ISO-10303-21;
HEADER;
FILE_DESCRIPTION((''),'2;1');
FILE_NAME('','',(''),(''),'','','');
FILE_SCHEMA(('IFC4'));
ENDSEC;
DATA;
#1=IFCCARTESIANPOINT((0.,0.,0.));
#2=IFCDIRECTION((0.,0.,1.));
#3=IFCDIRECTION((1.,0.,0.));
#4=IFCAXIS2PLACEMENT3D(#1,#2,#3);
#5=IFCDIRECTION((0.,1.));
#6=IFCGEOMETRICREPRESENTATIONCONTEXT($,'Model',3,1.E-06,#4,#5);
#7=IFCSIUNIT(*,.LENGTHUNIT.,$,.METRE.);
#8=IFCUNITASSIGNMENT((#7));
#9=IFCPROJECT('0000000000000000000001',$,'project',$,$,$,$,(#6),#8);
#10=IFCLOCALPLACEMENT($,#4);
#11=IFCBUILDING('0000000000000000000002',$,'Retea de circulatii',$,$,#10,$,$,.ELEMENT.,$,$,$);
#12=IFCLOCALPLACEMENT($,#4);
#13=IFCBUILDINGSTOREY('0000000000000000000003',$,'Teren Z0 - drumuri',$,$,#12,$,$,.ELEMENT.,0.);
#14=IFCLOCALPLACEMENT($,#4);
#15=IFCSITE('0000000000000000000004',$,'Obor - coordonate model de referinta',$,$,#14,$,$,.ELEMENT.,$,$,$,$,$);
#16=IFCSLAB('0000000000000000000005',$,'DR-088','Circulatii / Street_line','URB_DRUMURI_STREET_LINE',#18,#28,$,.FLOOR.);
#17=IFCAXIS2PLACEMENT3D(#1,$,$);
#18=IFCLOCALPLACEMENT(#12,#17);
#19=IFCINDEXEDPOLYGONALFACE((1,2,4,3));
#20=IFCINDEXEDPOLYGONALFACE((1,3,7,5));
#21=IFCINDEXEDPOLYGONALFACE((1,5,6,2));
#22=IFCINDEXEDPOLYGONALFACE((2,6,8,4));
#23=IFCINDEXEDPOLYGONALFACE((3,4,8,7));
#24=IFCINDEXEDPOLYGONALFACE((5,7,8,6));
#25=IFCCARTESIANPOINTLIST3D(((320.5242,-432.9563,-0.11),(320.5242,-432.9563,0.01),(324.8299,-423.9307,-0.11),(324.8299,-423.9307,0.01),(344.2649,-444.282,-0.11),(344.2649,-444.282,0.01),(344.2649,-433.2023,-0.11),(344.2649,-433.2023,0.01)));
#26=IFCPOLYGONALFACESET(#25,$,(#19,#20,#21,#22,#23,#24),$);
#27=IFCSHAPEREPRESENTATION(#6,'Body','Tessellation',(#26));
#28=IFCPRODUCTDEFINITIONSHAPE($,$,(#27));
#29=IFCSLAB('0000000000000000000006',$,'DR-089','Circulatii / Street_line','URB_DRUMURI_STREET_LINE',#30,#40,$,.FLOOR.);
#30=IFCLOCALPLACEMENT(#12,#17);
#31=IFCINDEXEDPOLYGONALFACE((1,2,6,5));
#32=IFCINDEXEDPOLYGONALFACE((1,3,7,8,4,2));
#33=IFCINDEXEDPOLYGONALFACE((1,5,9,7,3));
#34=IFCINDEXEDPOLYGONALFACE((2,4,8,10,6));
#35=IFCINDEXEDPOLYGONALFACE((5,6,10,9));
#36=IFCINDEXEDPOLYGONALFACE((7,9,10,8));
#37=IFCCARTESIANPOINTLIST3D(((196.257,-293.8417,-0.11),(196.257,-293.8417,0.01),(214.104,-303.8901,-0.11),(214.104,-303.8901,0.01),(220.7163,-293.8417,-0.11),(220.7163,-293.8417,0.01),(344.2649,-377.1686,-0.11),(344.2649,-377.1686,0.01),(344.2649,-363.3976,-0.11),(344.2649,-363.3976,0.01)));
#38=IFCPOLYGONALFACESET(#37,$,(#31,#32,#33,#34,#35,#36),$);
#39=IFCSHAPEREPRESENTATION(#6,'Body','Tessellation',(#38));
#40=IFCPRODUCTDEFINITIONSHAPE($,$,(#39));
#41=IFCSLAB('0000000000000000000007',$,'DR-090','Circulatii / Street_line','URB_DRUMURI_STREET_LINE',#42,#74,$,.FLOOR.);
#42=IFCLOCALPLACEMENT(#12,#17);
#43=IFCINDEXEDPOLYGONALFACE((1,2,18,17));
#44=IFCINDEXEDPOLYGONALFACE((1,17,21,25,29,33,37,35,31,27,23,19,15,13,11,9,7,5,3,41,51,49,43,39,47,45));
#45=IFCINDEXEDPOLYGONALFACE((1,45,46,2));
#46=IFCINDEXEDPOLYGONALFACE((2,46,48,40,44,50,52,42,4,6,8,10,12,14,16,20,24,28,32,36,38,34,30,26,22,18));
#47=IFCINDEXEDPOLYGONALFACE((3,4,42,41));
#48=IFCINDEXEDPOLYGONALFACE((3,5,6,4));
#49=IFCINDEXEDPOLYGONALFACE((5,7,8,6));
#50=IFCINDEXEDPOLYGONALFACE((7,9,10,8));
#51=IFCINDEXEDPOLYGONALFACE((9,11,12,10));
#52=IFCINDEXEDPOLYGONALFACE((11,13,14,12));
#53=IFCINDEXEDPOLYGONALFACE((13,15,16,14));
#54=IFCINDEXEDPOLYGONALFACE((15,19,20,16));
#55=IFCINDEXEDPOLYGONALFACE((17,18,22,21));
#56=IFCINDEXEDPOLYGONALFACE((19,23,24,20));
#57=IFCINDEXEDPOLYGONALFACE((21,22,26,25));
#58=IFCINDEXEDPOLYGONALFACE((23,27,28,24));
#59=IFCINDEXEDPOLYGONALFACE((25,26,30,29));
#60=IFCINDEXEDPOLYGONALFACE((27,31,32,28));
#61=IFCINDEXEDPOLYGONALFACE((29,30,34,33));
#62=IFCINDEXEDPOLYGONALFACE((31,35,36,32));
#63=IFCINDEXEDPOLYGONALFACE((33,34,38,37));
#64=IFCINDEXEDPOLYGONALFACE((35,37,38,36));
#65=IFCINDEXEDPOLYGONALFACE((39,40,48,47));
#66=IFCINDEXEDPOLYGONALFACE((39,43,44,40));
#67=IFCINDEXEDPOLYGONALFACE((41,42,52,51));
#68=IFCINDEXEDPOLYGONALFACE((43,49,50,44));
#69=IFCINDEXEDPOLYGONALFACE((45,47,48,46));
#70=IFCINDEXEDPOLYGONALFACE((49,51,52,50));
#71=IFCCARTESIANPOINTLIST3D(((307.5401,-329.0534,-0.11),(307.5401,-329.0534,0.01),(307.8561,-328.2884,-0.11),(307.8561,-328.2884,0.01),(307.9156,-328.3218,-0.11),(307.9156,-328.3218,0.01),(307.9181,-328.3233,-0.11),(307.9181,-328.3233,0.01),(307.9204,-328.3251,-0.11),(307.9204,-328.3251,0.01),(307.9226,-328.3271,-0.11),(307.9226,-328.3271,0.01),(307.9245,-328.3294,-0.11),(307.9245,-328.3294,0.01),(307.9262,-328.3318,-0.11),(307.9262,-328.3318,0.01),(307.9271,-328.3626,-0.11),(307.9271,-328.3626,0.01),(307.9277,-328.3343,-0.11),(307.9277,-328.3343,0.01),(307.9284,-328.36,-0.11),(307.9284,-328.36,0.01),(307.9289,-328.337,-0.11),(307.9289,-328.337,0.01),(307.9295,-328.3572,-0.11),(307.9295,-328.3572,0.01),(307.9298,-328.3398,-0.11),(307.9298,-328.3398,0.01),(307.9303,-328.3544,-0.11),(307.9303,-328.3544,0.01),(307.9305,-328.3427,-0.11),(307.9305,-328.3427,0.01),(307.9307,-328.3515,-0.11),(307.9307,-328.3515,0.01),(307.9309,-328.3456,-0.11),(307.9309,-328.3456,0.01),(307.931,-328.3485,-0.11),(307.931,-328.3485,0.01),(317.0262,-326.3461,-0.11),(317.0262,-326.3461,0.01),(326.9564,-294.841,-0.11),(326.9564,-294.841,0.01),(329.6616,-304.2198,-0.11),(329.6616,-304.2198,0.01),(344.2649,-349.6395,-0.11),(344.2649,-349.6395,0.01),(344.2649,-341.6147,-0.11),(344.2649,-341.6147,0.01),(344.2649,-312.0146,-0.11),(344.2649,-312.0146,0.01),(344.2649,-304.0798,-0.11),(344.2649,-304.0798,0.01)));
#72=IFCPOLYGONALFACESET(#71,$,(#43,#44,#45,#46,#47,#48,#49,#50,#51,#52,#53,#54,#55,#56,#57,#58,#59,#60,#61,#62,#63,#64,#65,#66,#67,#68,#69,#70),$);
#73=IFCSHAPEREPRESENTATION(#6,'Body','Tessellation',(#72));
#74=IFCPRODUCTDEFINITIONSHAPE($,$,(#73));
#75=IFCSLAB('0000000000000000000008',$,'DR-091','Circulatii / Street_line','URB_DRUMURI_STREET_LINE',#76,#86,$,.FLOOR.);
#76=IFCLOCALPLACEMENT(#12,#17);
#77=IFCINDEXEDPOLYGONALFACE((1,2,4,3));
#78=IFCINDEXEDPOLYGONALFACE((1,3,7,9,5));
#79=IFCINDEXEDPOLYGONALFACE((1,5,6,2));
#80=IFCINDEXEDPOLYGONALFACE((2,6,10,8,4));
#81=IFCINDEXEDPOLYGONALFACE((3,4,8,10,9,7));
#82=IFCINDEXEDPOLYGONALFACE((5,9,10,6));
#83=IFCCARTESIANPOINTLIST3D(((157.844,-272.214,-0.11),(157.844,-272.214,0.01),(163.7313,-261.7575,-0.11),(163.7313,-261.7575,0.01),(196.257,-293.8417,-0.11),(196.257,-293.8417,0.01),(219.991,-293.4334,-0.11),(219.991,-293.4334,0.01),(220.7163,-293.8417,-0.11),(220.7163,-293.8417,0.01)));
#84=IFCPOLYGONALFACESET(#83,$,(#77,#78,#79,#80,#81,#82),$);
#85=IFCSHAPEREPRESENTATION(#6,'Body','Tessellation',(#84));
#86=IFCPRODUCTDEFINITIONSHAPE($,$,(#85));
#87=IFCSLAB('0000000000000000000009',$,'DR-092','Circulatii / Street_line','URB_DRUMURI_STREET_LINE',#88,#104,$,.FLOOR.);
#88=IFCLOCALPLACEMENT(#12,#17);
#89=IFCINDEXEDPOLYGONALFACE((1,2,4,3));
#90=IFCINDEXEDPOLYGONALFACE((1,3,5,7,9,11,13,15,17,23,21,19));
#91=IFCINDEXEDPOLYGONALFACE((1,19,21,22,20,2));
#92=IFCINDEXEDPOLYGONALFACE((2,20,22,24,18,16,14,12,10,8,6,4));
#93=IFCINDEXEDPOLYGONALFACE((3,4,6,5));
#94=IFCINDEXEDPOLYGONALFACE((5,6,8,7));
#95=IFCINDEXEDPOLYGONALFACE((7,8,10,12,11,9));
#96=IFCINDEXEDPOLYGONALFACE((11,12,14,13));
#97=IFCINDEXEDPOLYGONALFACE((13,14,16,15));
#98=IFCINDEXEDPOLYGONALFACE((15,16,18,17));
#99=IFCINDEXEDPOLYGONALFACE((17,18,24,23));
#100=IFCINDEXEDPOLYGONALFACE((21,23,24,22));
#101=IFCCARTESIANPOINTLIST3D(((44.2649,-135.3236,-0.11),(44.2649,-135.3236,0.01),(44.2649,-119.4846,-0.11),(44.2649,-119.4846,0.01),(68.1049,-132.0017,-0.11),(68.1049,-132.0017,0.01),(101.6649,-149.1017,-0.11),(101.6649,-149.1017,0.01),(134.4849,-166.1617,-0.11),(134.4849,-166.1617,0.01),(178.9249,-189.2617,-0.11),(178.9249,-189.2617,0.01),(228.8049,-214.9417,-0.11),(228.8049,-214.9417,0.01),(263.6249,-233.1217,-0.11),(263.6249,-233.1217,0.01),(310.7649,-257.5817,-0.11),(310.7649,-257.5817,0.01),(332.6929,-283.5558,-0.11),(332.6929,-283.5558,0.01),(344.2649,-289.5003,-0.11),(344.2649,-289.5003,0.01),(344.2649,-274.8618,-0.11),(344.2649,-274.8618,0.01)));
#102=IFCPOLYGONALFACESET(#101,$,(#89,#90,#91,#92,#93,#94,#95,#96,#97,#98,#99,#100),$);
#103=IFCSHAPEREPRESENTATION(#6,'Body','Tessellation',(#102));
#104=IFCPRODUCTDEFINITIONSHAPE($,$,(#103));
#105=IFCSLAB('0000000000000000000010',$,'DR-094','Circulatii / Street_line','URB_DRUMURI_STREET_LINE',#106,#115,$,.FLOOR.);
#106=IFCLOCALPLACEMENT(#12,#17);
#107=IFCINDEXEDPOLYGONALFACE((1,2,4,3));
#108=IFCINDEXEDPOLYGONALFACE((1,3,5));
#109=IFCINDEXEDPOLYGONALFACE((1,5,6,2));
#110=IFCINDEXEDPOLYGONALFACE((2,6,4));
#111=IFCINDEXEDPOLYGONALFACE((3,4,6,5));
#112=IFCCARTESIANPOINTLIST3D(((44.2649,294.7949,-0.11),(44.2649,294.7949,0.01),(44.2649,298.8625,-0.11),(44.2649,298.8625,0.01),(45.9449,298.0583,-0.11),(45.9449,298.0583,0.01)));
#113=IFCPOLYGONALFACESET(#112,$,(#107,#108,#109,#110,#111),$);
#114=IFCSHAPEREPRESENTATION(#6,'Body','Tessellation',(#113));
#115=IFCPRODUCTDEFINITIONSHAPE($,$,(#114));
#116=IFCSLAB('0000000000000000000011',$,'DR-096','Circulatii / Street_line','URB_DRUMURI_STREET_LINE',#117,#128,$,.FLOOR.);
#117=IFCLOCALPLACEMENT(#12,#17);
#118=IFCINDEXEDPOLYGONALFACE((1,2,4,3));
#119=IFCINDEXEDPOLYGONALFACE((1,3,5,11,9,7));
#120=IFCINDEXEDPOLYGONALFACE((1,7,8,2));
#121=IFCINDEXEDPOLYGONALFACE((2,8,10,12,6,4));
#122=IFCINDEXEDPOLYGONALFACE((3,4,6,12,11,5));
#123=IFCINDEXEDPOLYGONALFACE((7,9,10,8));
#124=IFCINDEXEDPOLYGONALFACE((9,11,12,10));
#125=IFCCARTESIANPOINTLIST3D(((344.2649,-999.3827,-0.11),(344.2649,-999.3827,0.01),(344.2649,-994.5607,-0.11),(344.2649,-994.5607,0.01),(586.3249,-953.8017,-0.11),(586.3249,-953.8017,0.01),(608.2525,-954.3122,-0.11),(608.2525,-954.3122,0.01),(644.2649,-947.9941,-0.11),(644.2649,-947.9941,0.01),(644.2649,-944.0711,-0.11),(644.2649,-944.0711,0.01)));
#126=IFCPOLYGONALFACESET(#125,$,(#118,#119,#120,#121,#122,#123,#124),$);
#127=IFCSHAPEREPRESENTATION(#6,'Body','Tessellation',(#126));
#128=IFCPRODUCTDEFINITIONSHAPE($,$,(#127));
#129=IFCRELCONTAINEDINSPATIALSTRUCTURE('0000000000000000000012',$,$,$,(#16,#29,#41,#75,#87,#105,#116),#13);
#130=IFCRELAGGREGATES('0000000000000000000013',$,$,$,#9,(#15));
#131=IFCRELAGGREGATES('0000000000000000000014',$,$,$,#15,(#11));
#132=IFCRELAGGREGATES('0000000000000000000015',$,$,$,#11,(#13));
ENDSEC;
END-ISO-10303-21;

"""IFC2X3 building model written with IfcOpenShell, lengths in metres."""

from ifc_helpers import new_model, si_unit, direction, frame, origin_with_axes, place, context, project, spatial, polyline, outline, extrude, element, save


model = new_model("IFC2X3")

# Units and contexts
model_context = context("Model", 3, precision=1e-06, world=origin_with_axes(), true_north=direction((0.0, 1.0)))
ifc_project = project(units=[si_unit("LENGTHUNIT", "METRE")], contexts=[model_context])

# Site, building, storey
site_placement = place(None, origin_with_axes())
site = spatial("IfcSite", under=ifc_project, at=site_placement, Name="Obor - coordonate model de referinta", CompositionType="ELEMENT")
building_placement = place(None, origin_with_axes())
building = spatial("IfcBuilding", under=site, at=building_placement, Name="Retea de circulatii", CompositionType="ELEMENT")
storey_placement = place(None, origin_with_axes())
storey = spatial("IfcBuildingStorey", under=building, at=storey_placement, Name="Teren Z0 - drumuri", CompositionType="ELEMENT", Elevation=0.0)

# Slabs
slab_1_placement = place(None, origin_with_axes())
element("IfcSlab", 1, at=slab_1_placement, inside=storey, Name="DR-088", Description="Circulatii / Street_line", ObjectType="URB_DRUMURI_STREET_LINE", PredefinedType="FLOOR", context=model_context, shape_type="SweptSolid", body=[
    extrude(outline(polyline([(344.2649, -433.2023), (324.8299, -423.9307), (320.5242, -432.9563), (344.2649, -444.282), (344.2649, -433.2023)])), frame((0.0, 0.0, -0.11), z_axis=(0.0, 0.0, 1.0), x_axis=(1.0, 0.0, 0.0)), (0.0, 0.0, 1.0), 0.12),
])
slab_2_placement = place(None, origin_with_axes())
element("IfcSlab", 2, at=slab_2_placement, inside=storey, Name="DR-089", Description="Circulatii / Street_line", ObjectType="URB_DRUMURI_STREET_LINE", PredefinedType="FLOOR", context=model_context, shape_type="SweptSolid", body=[
    extrude(outline(polyline([(220.7163, -293.8417), (196.257, -293.8417), (214.104, -303.8901), (344.2649, -377.1686), (344.2649, -363.3976), (220.7163, -293.8417)])), frame((0.0, 0.0, -0.11), z_axis=(0.0, 0.0, 1.0), x_axis=(1.0, 0.0, 0.0)), (0.0, 0.0, 1.0), 0.12),
])
slab_3_placement = place(None, origin_with_axes())
element("IfcSlab", 3, at=slab_3_placement, inside=storey, Name="DR-090", Description="Circulatii / Street_line", ObjectType="URB_DRUMURI_STREET_LINE", PredefinedType="FLOOR", context=model_context, shape_type="SweptSolid", body=[
    extrude(outline(polyline([(307.9284, -328.36), (307.9271, -328.3626), (307.5401, -329.0534), (344.2649, -349.6395), (344.2649, -341.6147), (317.0262, -326.3461), (329.6616, -304.2198), (344.2649, -312.0146), (344.2649, -304.0798), (326.9564, -294.841), (307.8561, -328.2884), (307.9156, -328.3218), (307.9181, -328.3233), (307.9204, -328.3251), (307.9226, -328.3271), (307.9245, -328.3294), (307.9262, -328.3318), (307.9277, -328.3343), (307.9289, -328.337), (307.9298, -328.3398), (307.9305, -328.3427), (307.9309, -328.3456), (307.931, -328.3485), (307.9307, -328.3515), (307.9303, -328.3544), (307.9295, -328.3572), (307.9284, -328.36)])), frame((0.0, 0.0, -0.11), z_axis=(0.0, 0.0, 1.0), x_axis=(1.0, 0.0, 0.0)), (0.0, 0.0, 1.0), 0.12),
])
slab_4_placement = place(None, origin_with_axes())
element("IfcSlab", 4, at=slab_4_placement, inside=storey, Name="DR-091", Description="Circulatii / Street_line", ObjectType="URB_DRUMURI_STREET_LINE", PredefinedType="FLOOR", context=model_context, shape_type="SweptSolid", body=[
    extrude(outline(polyline([(163.7313, -261.7575), (157.844, -272.214), (196.257, -293.8417), (220.7163, -293.8417), (219.991, -293.4334), (163.7313, -261.7575)])), frame((0.0, 0.0, -0.11), z_axis=(0.0, 0.0, 1.0), x_axis=(1.0, 0.0, 0.0)), (0.0, 0.0, 1.0), 0.12),
])
slab_5_placement = place(None, origin_with_axes())
element("IfcSlab", 5, at=slab_5_placement, inside=storey, Name="DR-092", Description="Circulatii / Street_line", ObjectType="URB_DRUMURI_STREET_LINE", PredefinedType="FLOOR", context=model_context, shape_type="SweptSolid", body=[
    extrude(outline(polyline([(44.2649, -135.3236), (332.6929, -283.5558), (344.2649, -289.5003), (344.2649, -274.8618), (310.7649, -257.5817), (263.6249, -233.1217), (228.8049, -214.9417), (178.9249, -189.2617), (134.4849, -166.1617), (101.6649, -149.1017), (68.1049, -132.0017), (44.2649, -119.4846), (44.2649, -135.3236)])), frame((0.0, 0.0, -0.11), z_axis=(0.0, 0.0, 1.0), x_axis=(1.0, 0.0, 0.0)), (0.0, 0.0, 1.0), 0.12),
])
slab_6_placement = place(None, origin_with_axes())
element("IfcSlab", 6, at=slab_6_placement, inside=storey, Name="DR-094", Description="Circulatii / Street_line", ObjectType="URB_DRUMURI_STREET_LINE", PredefinedType="FLOOR", context=model_context, shape_type="SweptSolid", body=[
    extrude(outline(polyline([(44.2649, 294.7949), (45.9449, 298.0583), (44.2649, 298.8625), (44.2649, 294.7949)])), frame((0.0, 0.0, -0.11), z_axis=(0.0, 0.0, 1.0), x_axis=(1.0, 0.0, 0.0)), (0.0, 0.0, 1.0), 0.12),
])
slab_7_placement = place(None, origin_with_axes())
element("IfcSlab", 7, at=slab_7_placement, inside=storey, Name="DR-096", Description="Circulatii / Street_line", ObjectType="URB_DRUMURI_STREET_LINE", PredefinedType="FLOOR", context=model_context, shape_type="SweptSolid", body=[
    extrude(outline(polyline([(344.2649, -999.3827), (608.2525, -954.3122), (644.2649, -947.9941), (644.2649, -944.0711), (586.3249, -953.8017), (344.2649, -994.5607), (344.2649, -999.3827)])), frame((0.0, 0.0, -0.11), z_axis=(0.0, 0.0, 1.0), x_axis=(1.0, 0.0, 0.0)), (0.0, 0.0, 1.0), 0.12),
])

save(model, "model.ifc")
